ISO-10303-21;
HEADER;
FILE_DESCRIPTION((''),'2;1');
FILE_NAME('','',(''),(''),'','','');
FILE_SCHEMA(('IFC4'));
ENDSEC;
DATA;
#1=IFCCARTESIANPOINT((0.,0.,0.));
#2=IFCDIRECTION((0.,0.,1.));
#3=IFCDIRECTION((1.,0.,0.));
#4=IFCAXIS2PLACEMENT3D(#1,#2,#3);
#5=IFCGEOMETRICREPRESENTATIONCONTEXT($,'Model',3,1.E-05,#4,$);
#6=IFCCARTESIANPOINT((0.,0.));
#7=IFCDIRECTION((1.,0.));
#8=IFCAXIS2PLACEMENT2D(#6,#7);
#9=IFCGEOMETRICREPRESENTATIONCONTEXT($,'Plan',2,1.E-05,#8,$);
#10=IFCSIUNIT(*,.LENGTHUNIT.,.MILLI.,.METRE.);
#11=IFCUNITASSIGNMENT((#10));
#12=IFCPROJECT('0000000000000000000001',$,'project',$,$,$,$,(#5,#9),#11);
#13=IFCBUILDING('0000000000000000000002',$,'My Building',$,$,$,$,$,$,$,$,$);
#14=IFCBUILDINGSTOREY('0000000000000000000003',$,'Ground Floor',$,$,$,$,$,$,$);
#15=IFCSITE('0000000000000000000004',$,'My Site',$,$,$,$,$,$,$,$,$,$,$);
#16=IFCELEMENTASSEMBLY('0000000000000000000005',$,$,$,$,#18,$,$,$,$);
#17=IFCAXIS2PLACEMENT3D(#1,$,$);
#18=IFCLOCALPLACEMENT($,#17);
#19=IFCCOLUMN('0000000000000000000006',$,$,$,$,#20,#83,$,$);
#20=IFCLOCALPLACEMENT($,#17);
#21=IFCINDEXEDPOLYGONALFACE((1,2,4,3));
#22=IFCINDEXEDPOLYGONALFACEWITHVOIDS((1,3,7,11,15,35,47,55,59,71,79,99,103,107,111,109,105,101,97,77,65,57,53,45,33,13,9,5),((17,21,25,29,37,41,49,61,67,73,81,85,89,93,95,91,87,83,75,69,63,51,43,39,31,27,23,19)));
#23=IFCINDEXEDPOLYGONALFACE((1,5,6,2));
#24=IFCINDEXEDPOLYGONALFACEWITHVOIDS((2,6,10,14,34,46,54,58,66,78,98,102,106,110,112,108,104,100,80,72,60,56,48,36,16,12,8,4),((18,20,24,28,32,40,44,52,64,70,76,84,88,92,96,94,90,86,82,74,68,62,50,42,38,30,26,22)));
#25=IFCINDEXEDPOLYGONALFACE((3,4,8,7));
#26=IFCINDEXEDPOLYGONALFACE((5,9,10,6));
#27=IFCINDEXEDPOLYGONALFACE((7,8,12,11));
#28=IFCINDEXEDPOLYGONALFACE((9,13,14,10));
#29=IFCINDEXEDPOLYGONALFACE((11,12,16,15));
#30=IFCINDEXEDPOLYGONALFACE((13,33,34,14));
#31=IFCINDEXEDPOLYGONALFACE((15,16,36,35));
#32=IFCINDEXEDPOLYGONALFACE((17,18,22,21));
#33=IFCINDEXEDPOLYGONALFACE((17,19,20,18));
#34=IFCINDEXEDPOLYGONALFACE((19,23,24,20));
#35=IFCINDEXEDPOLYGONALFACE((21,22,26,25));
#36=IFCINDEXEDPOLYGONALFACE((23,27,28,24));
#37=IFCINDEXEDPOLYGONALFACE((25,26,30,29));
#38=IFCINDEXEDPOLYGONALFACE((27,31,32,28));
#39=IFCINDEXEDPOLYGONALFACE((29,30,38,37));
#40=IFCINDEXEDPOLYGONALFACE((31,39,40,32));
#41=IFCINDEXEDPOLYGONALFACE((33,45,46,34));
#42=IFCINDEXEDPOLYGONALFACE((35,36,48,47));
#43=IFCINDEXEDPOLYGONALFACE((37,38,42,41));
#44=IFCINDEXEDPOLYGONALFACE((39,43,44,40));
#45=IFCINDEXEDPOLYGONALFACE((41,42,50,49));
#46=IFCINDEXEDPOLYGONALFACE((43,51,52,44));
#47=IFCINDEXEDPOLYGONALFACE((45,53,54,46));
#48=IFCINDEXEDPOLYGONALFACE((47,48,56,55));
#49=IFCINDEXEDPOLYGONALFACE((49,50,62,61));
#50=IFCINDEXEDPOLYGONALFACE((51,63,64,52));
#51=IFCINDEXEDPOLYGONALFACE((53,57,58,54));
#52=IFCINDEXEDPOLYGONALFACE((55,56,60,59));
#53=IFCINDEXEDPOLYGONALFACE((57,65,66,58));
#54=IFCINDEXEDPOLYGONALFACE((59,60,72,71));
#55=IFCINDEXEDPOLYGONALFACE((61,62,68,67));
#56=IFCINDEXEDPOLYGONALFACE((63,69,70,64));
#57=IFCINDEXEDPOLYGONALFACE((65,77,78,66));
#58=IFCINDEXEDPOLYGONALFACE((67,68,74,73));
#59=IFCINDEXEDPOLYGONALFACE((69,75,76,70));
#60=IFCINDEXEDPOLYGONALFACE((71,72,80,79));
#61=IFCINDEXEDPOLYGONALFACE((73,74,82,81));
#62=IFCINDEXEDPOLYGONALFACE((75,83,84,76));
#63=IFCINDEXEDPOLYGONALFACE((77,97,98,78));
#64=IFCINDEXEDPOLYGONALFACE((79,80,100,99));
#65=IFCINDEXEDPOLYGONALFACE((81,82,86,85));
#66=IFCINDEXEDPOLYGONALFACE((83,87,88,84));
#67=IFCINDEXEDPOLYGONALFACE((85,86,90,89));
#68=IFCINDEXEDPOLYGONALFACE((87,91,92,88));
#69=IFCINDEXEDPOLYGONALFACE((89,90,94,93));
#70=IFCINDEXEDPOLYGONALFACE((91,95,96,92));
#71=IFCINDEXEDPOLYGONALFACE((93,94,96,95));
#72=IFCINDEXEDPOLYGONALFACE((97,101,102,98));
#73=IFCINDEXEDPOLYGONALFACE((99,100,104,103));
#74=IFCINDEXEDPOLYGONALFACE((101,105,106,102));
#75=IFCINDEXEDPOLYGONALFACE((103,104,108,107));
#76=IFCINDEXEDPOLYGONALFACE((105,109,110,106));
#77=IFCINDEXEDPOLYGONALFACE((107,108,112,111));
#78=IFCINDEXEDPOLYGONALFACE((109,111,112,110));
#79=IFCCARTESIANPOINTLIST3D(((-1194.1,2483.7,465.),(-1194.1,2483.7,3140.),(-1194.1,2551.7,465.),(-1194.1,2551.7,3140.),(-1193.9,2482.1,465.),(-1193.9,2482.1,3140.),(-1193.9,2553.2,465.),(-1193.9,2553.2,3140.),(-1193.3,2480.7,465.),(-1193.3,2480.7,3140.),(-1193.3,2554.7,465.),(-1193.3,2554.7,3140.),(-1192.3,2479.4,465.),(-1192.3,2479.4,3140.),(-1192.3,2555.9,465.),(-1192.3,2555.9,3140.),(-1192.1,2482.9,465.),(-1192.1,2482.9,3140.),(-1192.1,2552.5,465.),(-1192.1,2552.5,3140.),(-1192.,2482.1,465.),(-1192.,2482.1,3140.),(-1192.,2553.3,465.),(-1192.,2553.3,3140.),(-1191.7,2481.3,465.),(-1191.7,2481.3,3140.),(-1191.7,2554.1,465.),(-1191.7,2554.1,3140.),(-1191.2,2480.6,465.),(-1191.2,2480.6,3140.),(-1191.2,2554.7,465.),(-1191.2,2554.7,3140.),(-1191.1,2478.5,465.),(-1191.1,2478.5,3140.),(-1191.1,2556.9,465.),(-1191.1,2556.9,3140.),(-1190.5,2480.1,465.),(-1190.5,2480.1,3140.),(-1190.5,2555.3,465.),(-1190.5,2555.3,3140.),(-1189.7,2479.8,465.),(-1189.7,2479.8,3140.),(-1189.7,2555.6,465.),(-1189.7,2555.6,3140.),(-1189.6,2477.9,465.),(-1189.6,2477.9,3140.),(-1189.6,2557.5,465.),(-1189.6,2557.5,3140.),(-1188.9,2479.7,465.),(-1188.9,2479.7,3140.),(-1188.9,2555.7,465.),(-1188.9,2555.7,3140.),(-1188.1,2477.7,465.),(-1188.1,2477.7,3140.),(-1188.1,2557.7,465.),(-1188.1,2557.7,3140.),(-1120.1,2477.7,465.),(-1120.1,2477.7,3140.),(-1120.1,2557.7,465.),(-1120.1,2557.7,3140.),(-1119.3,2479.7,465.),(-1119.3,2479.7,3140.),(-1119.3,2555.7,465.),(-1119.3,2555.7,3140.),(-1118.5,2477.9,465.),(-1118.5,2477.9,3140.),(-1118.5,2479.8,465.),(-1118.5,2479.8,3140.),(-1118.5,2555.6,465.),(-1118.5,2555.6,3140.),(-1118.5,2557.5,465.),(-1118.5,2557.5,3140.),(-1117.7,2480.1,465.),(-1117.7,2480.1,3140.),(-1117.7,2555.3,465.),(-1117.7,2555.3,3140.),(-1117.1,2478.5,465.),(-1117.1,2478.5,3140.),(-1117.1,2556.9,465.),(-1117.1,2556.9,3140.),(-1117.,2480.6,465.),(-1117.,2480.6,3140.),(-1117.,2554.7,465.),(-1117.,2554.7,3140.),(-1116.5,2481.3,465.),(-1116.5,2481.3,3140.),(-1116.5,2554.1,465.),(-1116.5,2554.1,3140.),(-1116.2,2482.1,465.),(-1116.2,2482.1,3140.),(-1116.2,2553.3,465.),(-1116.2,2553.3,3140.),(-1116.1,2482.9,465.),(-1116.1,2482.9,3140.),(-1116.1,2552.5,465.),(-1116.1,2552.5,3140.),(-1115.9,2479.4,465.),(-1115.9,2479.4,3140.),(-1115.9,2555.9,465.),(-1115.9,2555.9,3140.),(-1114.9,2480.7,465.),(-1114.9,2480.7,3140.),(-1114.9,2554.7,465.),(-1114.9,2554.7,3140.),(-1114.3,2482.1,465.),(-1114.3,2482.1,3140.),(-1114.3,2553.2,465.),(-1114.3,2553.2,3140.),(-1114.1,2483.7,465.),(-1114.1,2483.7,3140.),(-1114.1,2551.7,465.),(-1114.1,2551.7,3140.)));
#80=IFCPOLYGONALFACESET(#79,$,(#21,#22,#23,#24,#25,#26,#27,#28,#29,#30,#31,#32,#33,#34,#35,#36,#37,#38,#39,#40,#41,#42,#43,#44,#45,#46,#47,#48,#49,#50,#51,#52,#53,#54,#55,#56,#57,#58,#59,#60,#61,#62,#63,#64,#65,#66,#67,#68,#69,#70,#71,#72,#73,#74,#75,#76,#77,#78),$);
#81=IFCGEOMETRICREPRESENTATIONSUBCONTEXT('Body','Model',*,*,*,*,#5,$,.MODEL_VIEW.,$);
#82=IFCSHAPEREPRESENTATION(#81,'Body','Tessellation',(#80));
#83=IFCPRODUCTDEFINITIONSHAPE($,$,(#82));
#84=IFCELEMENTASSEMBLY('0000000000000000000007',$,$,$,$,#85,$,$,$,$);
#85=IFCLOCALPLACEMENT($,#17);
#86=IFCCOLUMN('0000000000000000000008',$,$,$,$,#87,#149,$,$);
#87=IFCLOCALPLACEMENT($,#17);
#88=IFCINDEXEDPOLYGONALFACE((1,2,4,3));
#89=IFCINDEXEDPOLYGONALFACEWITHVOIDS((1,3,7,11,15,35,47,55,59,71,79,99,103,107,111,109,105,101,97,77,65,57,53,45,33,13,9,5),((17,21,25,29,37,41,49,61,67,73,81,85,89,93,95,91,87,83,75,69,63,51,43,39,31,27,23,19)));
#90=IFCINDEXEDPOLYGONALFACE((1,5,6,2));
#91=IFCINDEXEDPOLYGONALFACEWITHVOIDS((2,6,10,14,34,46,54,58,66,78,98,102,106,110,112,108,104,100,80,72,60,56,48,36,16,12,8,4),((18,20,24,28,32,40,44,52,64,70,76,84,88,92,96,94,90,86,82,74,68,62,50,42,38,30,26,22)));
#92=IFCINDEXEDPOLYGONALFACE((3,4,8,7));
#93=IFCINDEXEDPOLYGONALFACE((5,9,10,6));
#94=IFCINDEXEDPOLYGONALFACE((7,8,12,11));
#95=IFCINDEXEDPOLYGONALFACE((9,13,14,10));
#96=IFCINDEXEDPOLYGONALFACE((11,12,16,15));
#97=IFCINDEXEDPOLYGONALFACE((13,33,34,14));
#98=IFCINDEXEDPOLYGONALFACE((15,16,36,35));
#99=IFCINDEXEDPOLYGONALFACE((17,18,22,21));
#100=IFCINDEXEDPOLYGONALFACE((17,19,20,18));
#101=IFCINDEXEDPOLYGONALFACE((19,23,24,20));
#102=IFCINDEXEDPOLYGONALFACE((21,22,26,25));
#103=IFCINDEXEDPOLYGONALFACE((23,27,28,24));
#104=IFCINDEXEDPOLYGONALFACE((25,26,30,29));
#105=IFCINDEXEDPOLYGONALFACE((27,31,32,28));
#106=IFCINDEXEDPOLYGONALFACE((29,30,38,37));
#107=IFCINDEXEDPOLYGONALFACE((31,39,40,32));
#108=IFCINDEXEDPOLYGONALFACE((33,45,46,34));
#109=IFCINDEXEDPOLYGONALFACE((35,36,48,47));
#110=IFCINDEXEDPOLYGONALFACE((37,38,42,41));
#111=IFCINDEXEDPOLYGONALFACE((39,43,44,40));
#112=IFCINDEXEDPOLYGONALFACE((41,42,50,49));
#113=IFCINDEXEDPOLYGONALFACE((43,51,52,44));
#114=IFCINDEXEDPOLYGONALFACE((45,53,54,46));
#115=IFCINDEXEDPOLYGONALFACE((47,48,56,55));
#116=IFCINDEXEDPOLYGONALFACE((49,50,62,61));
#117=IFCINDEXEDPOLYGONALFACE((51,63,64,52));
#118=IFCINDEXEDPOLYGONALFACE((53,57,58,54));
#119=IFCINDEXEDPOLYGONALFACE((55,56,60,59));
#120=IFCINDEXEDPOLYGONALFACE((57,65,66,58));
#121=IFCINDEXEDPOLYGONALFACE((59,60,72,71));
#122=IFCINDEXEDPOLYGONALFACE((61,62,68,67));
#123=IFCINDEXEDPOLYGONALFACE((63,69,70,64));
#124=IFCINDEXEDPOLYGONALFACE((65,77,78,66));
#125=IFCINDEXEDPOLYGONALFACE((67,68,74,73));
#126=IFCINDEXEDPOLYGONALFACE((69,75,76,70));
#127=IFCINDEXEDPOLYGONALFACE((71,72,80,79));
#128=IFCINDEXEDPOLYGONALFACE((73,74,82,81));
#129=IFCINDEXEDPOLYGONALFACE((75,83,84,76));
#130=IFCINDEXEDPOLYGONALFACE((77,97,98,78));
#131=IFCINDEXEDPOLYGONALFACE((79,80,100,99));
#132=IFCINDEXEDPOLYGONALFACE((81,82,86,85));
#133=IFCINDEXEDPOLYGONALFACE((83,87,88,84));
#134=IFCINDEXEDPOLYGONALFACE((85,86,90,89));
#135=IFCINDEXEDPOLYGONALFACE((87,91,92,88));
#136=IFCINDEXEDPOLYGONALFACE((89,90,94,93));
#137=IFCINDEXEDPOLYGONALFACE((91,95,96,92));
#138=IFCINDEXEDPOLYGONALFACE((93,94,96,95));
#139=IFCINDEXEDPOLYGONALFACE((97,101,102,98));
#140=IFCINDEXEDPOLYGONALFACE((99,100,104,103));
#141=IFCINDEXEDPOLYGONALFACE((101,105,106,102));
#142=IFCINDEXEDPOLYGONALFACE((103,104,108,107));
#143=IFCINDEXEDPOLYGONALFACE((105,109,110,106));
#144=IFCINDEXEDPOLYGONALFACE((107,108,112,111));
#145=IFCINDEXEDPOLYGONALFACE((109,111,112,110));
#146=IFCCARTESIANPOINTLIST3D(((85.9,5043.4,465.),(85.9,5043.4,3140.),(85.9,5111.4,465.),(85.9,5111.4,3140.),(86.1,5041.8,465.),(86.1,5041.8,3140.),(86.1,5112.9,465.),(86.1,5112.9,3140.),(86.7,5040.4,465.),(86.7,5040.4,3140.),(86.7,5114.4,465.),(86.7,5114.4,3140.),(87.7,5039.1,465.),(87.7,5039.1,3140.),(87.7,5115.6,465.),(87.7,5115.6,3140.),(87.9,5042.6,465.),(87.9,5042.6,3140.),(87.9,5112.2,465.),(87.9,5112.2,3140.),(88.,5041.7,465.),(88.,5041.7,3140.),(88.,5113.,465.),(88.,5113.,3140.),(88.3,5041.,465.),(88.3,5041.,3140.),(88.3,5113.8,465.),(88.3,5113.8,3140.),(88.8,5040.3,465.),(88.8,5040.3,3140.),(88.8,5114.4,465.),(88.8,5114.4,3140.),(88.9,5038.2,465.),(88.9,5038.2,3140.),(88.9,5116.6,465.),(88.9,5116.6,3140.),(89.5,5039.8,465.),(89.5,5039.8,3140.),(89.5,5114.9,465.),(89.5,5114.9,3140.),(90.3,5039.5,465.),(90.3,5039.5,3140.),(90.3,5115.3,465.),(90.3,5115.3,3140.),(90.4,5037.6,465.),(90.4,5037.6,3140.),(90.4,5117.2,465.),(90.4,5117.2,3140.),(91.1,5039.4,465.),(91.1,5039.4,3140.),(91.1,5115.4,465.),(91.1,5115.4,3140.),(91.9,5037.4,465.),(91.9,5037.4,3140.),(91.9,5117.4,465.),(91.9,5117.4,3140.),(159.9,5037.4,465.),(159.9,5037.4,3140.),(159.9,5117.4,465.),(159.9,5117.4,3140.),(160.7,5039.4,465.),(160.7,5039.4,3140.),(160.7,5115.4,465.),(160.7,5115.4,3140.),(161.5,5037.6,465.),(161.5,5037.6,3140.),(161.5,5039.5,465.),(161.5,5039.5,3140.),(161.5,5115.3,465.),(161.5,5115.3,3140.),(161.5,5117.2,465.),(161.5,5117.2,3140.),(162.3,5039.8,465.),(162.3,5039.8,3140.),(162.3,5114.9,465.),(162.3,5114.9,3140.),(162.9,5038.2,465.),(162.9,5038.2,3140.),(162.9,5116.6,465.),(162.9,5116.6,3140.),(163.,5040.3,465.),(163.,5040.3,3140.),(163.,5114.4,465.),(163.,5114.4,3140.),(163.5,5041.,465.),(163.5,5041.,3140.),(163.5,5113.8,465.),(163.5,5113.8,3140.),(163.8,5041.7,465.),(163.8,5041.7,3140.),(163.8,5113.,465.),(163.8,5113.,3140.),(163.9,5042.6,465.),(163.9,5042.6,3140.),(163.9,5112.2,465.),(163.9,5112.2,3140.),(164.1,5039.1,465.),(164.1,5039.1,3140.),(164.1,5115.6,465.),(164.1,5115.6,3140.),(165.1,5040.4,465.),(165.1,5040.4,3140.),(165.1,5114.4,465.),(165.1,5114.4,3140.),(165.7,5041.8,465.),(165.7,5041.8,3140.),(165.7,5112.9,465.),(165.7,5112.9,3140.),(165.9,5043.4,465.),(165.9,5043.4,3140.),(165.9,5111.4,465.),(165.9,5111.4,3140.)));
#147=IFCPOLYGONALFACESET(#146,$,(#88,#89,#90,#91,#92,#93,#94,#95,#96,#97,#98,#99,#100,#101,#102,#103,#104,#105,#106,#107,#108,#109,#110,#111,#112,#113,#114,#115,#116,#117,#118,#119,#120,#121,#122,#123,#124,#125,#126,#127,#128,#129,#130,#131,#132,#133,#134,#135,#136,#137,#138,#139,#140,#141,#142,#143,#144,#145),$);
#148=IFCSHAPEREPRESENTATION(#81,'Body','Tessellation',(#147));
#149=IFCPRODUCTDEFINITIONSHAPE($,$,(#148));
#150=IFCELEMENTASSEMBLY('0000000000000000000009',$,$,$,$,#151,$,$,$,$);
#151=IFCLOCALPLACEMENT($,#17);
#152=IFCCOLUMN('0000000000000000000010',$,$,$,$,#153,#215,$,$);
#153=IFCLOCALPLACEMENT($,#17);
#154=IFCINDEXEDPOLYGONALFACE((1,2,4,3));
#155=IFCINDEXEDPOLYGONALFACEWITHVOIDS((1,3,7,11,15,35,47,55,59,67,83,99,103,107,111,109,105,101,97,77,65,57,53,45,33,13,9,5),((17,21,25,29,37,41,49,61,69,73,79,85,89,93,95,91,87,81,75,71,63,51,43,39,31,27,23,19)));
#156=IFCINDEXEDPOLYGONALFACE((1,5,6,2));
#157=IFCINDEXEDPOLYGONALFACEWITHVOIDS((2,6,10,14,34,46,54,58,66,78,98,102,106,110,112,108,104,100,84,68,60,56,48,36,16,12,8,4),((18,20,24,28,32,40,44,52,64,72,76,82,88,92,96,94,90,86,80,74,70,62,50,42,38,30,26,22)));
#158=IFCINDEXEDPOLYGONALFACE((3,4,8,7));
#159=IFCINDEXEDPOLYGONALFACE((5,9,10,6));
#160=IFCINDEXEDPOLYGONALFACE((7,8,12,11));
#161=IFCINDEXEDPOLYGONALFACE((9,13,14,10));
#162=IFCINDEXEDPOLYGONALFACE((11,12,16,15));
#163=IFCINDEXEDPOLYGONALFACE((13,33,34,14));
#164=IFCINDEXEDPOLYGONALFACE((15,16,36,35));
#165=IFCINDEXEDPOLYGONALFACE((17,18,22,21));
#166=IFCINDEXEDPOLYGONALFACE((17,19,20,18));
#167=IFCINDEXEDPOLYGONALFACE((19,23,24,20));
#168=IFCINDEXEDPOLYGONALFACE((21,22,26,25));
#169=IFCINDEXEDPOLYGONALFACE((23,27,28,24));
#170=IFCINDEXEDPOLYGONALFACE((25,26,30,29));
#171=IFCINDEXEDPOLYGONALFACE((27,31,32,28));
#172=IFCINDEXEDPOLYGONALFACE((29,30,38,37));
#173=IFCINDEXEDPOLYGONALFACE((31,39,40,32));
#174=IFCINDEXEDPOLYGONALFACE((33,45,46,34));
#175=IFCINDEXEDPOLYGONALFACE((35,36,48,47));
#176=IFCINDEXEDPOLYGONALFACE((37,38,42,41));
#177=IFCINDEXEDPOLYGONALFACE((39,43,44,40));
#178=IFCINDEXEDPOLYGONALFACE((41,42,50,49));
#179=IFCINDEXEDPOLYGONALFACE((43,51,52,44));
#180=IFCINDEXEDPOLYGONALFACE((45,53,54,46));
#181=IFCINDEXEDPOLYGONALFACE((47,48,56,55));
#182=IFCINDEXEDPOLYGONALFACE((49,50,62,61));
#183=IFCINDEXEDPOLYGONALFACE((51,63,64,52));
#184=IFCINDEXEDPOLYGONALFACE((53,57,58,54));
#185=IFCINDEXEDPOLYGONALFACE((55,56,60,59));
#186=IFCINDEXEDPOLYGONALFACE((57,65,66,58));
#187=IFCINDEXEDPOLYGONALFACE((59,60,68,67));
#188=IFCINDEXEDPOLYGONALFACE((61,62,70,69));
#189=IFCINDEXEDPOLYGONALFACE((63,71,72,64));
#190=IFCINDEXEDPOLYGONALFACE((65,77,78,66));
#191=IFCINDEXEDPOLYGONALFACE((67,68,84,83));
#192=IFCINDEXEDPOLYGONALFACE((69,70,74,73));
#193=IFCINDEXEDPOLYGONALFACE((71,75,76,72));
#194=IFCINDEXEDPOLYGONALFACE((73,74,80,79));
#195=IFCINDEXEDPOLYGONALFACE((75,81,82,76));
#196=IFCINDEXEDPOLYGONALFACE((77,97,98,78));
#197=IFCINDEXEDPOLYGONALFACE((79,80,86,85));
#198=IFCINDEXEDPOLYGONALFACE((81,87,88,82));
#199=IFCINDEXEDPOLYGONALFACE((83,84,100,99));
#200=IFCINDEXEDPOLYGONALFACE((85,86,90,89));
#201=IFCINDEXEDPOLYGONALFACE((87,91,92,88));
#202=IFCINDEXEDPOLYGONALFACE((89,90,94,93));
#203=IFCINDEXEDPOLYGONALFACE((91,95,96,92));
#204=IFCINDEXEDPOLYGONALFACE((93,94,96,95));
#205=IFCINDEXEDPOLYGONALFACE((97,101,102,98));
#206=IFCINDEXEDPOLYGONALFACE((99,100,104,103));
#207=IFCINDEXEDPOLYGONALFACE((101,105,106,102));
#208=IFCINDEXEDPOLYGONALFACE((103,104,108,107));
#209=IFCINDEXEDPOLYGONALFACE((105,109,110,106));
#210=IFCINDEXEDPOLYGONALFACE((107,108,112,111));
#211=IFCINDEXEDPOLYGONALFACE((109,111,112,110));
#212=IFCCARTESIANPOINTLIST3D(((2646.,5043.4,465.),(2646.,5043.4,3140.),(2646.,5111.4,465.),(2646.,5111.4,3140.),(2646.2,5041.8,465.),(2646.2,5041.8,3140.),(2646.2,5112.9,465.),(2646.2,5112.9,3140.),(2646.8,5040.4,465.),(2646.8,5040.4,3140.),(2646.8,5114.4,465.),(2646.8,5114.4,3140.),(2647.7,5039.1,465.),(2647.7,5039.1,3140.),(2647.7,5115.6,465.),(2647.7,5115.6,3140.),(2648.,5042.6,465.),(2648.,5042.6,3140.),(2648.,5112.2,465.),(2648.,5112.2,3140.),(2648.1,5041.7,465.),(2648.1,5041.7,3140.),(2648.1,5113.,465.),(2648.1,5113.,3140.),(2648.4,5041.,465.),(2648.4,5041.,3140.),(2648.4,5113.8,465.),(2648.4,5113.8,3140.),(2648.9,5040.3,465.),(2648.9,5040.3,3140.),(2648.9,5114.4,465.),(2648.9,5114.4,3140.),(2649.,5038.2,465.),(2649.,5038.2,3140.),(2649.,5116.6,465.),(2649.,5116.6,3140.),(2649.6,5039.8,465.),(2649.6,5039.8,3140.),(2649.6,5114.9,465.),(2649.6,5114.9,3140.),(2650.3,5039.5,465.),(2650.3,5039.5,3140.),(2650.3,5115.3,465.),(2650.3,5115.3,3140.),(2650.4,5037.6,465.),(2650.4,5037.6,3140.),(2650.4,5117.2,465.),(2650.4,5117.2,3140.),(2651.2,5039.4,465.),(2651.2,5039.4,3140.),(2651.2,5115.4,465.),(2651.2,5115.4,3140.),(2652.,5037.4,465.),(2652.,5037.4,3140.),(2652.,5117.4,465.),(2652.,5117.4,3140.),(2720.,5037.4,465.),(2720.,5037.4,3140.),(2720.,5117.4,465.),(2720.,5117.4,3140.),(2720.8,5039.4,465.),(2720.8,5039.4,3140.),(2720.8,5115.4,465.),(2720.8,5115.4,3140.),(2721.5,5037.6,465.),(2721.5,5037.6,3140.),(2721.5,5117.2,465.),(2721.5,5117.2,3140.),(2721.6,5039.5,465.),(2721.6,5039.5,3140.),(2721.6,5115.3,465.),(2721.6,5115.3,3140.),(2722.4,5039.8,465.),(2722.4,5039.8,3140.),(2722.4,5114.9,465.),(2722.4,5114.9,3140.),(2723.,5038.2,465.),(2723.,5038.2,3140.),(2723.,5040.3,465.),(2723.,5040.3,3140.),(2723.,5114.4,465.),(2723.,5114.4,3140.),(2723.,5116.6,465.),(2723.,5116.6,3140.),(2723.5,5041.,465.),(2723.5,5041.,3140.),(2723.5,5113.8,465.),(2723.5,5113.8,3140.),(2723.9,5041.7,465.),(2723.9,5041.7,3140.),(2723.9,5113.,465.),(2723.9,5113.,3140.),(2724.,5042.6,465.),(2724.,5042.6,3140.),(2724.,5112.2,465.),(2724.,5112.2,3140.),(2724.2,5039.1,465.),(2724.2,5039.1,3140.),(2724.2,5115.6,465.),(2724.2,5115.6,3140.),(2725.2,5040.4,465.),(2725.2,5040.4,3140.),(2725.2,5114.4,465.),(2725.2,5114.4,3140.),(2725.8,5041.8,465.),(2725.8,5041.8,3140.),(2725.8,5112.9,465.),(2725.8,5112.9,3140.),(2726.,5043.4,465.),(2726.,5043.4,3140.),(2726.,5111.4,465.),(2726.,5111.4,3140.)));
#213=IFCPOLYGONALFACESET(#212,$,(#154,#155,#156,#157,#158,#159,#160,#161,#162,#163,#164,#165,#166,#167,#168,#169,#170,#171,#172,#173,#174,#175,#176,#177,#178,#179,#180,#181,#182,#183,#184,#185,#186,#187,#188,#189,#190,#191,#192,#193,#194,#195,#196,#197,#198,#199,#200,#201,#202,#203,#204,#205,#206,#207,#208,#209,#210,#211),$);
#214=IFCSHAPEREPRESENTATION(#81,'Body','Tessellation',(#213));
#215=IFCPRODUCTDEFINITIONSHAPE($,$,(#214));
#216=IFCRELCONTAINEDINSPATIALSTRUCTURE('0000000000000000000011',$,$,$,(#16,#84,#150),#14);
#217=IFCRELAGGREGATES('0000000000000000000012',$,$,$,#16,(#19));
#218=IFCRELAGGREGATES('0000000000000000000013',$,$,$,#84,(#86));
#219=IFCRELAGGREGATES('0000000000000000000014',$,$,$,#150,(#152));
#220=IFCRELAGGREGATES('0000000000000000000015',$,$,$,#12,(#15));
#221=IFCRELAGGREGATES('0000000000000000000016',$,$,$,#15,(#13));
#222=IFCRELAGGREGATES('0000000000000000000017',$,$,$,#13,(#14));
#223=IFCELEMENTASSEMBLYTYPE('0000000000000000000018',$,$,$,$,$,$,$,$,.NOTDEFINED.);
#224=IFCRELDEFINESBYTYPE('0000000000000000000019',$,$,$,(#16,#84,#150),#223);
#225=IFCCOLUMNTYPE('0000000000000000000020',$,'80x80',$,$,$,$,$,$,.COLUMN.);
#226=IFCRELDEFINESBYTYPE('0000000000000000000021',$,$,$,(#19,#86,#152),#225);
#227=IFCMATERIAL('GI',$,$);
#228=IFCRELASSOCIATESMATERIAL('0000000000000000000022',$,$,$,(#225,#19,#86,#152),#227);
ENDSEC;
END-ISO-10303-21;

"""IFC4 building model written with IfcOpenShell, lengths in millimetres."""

from ifc_helpers import new_model, si_unit, frame, origin_with_axes, origin_2d_with_axis, place, context, subcontext, project, spatial, hollow_rectangle, extrude, material, material_profile, profile_set, profile_usage, type_object, element, aggregate, save


model = new_model("IFC4")

# Units and contexts
model_context = context("Model", 3, precision=1e-05, world=origin_with_axes())
plan_context = context("Plan", 2, precision=1e-05, world=origin_2d_with_axis())
body_context = subcontext(model_context, "Body", "Model", "MODEL_VIEW")
ifc_project = project(units=[si_unit("LENGTHUNIT", "METRE", prefix="MILLI")], contexts=[model_context, plan_context])

# Site, building, storey
site = spatial("IfcSite", under=ifc_project, Name="My Site")
building = spatial("IfcBuilding", under=site, Name="My Building")
storey = spatial("IfcBuildingStorey", under=building, Name="Ground Floor")

# Element assemblies, columns
element_assembly_type_1 = type_object("IfcElementAssemblyType", PredefinedType="NOTDEFINED")
ifc_material = material(Name="GI")
ifc_material_profile_1 = material_profile(ifc_material, hollow_rectangle(XDim=80.0, YDim=80.0, WallThickness=2.0, InnerFilletRadius=3.2, OuterFilletRadius=6.0))
ifc_profile_set_1 = profile_set([ifc_material_profile_1], Name="80x80 GI Rectangular Hollow")
column_type = type_object("IfcColumnType", Name="80x80", PredefinedType="COLUMN", material=ifc_profile_set_1)
assembly_1_placement = place(None, frame((-1154.1, 2517.7, 465.0), z_axis=(0.0, 0.0, 1.0), x_axis=(1.0, 0.0, 0.0)))
assembly_1 = element("IfcElementAssembly", 1, at=assembly_1_placement, inside=storey, type_object=element_assembly_type_1)
ifc_profile_usage_1 = profile_usage(ifc_profile_set_1)
column_1_placement = place(assembly_1_placement, origin_with_axes())
column_1 = element("IfcColumn", 2, at=column_1_placement, type_object=column_type, material=ifc_profile_usage_1, context=body_context, shape_type="SweptSolid", body=[
    extrude(hollow_rectangle(XDim=80.0, YDim=80.0, WallThickness=2.0, InnerFilletRadius=3.2, OuterFilletRadius=6.0), origin_with_axes(), (0.0, 0.0, 1.0), 2675.0),
])
aggregate(assembly_1, [column_1])
assembly_2_placement = place(None, frame((125.9, 5077.4, 465.0), z_axis=(0.0, 0.0, 1.0), x_axis=(1.0, 0.0, 0.0)))
assembly_2 = element("IfcElementAssembly", 3, at=assembly_2_placement, inside=storey, type_object=element_assembly_type_1)
ifc_profile_usage_2 = profile_usage(ifc_profile_set_1)
column_2_placement = place(assembly_2_placement, origin_with_axes())
column_2 = element("IfcColumn", 4, at=column_2_placement, type_object=column_type, material=ifc_profile_usage_2, context=body_context, shape_type="SweptSolid", body=[
    extrude(hollow_rectangle(XDim=80.0, YDim=80.0, WallThickness=2.0, InnerFilletRadius=3.2, OuterFilletRadius=6.0), origin_with_axes(), (0.0, 0.0, 1.0), 2675.0),
])
aggregate(assembly_2, [column_2])
assembly_3_placement = place(None, frame((2686.0, 5077.4, 465.0), z_axis=(0.0, 0.0, 1.0), x_axis=(1.0, 0.0, 0.0)))
assembly_3 = element("IfcElementAssembly", 5, at=assembly_3_placement, inside=storey, type_object=element_assembly_type_1)
ifc_profile_usage_3 = profile_usage(ifc_profile_set_1)
column_3_placement = place(assembly_3_placement, origin_with_axes())
column_3 = element("IfcColumn", 6, at=column_3_placement, type_object=column_type, material=ifc_profile_usage_3, context=body_context, shape_type="SweptSolid", body=[
    extrude(hollow_rectangle(XDim=80.0, YDim=80.0, WallThickness=2.0, InnerFilletRadius=3.2, OuterFilletRadius=6.0), origin_with_axes(), (0.0, 0.0, 1.0), 2675.0),
])
aggregate(assembly_3, [column_3])

save(model, "model.ifc")
